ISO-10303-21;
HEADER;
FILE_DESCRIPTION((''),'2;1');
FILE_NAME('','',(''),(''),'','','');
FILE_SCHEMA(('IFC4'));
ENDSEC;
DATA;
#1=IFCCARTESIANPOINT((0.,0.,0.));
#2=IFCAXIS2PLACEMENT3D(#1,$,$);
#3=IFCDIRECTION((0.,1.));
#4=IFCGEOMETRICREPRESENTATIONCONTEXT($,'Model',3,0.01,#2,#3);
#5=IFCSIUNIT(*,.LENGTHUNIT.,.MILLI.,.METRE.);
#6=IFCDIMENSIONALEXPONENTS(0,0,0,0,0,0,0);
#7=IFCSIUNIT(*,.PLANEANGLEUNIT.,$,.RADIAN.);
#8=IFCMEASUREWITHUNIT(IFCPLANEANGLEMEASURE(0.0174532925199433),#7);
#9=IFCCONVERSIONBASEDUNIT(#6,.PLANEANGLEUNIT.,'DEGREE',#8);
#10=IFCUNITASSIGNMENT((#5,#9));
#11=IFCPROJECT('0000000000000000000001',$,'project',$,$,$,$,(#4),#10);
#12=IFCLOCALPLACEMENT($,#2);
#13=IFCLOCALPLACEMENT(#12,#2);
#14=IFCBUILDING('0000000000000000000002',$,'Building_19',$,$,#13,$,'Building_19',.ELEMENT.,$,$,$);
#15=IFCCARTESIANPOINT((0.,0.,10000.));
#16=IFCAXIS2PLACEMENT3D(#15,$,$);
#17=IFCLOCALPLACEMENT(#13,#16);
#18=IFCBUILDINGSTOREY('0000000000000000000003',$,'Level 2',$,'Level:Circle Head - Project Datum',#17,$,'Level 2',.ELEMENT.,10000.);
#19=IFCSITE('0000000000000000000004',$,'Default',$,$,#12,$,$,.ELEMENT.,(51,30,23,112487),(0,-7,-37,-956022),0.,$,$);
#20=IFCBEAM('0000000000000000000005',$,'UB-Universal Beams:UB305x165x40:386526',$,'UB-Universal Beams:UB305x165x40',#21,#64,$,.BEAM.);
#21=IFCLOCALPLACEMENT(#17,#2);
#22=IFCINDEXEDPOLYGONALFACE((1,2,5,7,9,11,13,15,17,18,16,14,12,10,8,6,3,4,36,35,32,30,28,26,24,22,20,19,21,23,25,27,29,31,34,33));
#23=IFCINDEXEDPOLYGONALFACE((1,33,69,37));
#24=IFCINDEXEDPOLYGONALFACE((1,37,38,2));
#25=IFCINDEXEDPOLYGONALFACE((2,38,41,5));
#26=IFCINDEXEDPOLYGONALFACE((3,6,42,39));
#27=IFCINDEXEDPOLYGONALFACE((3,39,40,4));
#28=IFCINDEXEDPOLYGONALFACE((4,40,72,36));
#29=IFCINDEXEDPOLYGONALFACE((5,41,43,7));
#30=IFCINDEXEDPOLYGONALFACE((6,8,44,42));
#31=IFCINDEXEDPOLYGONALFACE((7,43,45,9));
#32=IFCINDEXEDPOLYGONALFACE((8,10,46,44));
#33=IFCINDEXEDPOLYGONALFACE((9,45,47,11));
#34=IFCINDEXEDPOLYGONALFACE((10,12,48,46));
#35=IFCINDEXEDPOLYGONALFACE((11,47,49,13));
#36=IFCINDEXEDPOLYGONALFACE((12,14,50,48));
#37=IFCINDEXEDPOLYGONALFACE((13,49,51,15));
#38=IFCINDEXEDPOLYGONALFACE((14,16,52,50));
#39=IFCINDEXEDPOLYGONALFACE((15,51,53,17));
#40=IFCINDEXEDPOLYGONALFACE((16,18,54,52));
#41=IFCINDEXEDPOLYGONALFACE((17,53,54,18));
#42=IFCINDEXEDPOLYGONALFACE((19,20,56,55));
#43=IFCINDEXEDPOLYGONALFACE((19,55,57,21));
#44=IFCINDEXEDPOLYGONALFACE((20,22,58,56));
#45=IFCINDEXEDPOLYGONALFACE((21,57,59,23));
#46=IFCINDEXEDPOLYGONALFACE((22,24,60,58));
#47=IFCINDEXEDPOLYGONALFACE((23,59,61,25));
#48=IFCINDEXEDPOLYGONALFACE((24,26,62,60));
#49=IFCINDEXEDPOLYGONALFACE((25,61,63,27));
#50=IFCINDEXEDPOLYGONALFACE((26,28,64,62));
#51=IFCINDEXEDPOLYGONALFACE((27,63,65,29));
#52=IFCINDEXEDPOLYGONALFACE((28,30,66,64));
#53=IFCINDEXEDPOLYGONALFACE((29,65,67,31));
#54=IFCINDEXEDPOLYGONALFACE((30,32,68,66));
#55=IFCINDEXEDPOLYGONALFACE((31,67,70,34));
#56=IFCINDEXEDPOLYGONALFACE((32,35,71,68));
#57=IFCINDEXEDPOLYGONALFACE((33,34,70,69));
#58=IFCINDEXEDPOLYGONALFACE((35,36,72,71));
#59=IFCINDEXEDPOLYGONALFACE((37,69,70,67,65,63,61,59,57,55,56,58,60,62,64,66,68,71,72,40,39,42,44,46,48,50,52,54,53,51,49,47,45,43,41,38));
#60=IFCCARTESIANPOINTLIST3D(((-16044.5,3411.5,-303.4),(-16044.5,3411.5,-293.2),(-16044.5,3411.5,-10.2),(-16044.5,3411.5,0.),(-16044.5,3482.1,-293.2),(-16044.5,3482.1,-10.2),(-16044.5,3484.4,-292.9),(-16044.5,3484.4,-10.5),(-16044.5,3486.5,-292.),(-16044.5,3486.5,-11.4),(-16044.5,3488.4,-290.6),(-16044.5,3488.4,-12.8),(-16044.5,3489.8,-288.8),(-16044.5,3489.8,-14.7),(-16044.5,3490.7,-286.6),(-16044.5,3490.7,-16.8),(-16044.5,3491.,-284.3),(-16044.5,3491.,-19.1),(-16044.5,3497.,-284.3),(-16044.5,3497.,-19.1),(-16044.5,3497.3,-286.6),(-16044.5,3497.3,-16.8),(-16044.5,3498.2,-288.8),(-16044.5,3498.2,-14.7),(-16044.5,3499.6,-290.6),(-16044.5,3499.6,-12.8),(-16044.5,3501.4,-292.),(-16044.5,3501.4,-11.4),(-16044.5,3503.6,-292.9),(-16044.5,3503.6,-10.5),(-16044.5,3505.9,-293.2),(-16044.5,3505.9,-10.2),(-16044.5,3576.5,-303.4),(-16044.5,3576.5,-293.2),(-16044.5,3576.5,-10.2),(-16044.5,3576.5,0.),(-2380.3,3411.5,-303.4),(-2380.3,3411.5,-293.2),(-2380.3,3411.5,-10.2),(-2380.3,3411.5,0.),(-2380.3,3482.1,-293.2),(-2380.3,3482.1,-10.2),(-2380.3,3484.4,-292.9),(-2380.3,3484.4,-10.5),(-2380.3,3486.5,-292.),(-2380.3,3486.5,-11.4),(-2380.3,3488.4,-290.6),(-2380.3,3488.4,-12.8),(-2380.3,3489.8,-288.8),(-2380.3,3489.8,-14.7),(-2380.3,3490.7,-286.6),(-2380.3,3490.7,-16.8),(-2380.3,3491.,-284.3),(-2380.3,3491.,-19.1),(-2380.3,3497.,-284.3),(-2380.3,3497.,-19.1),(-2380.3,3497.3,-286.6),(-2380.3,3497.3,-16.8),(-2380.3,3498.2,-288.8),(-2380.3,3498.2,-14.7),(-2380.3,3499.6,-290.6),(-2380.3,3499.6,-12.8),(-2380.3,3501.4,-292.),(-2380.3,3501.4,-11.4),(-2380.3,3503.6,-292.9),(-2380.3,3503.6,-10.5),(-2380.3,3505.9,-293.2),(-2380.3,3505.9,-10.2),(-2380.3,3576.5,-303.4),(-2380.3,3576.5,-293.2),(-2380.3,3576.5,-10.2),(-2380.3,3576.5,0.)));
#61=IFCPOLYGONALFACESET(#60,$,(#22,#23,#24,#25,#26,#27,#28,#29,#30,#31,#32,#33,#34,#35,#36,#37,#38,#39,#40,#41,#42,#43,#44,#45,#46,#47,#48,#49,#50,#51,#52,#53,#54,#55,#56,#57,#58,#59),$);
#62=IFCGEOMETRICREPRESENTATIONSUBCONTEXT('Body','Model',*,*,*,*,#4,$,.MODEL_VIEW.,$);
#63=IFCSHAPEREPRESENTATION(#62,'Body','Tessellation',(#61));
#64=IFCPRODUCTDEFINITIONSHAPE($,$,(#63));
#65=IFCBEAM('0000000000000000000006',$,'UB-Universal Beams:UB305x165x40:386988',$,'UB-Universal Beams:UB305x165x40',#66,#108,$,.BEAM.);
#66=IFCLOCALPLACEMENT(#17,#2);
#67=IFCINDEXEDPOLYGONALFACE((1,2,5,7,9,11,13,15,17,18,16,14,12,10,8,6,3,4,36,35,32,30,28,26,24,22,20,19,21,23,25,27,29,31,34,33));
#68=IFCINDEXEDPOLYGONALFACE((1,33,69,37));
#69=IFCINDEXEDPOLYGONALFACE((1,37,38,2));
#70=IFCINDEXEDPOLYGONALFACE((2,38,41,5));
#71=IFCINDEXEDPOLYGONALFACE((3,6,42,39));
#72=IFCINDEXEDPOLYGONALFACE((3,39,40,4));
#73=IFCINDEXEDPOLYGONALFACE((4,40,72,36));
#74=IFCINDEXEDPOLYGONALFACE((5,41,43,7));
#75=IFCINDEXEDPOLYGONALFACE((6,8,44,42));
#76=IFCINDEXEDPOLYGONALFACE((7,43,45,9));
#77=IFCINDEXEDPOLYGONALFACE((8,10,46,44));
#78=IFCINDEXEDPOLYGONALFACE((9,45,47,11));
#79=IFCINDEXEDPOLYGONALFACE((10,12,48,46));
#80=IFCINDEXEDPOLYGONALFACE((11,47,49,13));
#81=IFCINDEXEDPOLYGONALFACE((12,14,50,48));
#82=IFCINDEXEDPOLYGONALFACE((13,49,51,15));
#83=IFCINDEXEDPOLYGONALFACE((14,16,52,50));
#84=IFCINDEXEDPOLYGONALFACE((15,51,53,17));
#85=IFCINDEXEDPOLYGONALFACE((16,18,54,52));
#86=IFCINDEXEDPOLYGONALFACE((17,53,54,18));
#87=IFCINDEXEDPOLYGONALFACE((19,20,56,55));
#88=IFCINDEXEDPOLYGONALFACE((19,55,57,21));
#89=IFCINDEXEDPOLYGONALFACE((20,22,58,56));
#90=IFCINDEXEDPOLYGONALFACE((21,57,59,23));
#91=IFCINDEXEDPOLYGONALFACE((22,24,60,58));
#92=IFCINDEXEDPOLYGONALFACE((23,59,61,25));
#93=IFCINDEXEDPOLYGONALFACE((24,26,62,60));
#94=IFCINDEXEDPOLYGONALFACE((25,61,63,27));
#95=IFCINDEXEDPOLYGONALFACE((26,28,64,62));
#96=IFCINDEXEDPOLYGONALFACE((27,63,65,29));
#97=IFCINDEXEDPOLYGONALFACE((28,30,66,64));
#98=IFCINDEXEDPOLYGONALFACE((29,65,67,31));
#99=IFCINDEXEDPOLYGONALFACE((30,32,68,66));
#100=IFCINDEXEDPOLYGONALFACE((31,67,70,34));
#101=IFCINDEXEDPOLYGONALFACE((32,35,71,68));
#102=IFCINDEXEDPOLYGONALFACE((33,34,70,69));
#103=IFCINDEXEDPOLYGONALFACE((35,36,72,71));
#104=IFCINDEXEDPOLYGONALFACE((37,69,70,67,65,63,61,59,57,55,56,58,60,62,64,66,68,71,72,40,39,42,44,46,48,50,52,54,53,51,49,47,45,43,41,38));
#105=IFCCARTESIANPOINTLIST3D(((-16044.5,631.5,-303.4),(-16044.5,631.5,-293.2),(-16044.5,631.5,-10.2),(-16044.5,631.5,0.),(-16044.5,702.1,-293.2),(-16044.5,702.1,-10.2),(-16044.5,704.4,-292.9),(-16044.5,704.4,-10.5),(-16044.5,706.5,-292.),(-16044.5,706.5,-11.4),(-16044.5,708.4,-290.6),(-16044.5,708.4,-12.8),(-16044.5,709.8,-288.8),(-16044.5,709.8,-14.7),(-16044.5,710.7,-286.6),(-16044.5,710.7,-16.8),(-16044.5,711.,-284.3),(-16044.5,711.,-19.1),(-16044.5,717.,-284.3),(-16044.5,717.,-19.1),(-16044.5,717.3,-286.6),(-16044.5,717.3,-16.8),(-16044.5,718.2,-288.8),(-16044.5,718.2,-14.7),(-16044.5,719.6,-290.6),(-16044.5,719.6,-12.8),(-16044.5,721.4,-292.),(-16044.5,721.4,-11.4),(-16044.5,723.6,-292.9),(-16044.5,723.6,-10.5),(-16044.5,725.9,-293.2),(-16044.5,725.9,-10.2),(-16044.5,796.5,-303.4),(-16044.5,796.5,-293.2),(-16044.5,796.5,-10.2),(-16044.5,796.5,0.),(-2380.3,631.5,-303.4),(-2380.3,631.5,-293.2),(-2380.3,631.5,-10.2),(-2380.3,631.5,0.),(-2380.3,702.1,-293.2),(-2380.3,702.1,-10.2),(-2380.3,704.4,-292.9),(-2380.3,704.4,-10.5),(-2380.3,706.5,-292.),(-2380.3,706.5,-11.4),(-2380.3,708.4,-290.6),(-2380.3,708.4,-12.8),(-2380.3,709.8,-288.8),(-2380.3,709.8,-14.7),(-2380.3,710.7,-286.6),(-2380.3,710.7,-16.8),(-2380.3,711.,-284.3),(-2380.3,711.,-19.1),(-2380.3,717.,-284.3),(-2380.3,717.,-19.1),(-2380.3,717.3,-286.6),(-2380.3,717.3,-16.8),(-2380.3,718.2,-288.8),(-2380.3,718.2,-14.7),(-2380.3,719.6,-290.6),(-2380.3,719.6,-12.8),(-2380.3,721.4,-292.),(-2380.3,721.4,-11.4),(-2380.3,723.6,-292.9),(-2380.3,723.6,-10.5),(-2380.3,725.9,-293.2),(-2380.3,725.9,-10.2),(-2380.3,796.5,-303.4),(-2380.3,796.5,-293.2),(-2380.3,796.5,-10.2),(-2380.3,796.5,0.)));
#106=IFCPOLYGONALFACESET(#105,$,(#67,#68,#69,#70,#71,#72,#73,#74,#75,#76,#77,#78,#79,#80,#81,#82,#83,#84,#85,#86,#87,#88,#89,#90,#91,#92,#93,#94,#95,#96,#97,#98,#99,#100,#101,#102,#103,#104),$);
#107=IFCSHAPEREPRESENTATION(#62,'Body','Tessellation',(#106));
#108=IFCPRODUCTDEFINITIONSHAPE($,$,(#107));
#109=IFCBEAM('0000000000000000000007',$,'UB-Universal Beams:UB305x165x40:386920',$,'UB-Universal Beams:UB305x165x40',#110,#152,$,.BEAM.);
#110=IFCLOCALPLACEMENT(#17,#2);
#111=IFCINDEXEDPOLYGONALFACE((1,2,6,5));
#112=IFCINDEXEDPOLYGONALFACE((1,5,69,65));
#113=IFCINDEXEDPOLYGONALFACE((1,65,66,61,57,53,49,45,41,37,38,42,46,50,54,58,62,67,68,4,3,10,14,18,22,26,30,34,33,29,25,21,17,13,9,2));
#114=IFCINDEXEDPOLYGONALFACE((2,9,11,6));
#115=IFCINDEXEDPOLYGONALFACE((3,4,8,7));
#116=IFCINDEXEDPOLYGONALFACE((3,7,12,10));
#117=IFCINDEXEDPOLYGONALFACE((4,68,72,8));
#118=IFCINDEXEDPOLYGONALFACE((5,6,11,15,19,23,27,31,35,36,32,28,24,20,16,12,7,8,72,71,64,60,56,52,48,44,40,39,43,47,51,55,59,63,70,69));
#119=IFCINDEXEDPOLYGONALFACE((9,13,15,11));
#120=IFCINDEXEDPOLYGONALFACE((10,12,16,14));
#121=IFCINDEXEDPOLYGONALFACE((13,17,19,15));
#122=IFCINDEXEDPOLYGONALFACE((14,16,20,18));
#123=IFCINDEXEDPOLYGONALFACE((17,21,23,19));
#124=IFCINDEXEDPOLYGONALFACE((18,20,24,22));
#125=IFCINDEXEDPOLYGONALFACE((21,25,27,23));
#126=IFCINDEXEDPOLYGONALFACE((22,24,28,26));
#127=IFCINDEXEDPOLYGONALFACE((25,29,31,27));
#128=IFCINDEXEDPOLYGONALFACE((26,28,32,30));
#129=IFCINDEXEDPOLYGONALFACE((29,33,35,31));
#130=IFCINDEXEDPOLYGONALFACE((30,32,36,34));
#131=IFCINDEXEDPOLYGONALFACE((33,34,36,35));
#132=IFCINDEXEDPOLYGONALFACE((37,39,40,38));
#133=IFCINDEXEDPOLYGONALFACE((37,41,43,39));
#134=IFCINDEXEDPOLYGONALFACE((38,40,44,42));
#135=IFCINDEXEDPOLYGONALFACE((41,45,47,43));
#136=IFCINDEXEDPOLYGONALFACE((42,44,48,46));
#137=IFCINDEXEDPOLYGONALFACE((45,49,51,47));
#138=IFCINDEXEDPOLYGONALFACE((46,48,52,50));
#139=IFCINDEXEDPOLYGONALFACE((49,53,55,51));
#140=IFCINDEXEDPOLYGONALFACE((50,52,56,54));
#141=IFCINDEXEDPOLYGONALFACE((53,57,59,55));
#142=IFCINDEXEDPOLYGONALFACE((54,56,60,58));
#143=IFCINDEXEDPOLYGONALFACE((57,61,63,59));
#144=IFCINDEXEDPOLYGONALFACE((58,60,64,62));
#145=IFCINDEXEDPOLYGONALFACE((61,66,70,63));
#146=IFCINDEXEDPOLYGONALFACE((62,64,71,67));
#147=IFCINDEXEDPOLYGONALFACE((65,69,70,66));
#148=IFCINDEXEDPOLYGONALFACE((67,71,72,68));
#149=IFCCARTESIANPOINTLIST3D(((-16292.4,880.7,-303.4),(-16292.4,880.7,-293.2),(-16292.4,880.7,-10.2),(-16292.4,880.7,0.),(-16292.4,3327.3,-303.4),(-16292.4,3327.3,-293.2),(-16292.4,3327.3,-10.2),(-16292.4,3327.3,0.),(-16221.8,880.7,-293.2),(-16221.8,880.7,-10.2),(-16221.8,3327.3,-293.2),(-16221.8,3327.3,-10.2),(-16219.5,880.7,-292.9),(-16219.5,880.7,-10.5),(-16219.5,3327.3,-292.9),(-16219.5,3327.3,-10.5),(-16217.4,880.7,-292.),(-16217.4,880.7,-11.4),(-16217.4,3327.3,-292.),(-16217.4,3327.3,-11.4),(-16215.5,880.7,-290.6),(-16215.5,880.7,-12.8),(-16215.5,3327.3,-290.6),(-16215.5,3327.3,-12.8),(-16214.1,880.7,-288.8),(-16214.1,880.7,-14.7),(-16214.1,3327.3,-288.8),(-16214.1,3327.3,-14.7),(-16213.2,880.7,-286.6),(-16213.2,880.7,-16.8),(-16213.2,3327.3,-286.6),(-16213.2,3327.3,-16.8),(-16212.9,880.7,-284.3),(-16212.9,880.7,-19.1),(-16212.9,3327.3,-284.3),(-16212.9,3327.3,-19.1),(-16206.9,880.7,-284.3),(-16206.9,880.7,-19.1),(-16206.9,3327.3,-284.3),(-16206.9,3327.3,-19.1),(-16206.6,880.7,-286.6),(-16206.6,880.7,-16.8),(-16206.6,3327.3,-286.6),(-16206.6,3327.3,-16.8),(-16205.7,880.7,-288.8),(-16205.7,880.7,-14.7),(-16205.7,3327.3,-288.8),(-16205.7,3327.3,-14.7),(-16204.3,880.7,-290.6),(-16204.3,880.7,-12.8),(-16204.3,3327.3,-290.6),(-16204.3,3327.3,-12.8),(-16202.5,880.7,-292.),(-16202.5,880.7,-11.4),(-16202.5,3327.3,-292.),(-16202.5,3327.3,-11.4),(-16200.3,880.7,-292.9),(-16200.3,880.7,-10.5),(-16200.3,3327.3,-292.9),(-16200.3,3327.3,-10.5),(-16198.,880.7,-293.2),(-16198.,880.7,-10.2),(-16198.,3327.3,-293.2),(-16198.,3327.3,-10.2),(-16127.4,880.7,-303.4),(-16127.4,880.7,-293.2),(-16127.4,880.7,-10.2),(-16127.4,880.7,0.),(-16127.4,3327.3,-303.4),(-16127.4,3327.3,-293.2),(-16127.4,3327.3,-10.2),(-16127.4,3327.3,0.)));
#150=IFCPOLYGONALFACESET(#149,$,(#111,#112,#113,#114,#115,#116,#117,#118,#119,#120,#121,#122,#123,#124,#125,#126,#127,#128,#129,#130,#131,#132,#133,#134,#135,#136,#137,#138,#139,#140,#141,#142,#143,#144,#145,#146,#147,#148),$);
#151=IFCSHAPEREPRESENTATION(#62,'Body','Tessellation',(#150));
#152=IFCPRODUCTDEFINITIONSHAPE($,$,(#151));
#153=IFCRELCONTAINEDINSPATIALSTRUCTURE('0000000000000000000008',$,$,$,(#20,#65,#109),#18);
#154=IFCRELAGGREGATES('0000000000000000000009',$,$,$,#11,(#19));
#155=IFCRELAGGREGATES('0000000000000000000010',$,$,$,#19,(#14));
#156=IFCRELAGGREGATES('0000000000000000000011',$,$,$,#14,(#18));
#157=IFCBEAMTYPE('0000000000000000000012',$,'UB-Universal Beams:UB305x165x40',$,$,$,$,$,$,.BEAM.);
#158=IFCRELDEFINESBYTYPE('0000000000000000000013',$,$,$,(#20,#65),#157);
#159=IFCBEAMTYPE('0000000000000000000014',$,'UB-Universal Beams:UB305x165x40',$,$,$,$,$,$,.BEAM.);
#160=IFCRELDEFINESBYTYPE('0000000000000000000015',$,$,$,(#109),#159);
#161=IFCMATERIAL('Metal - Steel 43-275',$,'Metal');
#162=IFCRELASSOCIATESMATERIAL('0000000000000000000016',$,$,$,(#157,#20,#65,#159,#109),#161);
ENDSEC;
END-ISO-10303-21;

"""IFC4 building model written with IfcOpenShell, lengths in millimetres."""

from ifc_helpers import new_model, entity, si_unit, converted_unit, direction, frame, origin, place, context, subcontext, project, spatial, line, arc, indexed_curve, outline, extrude, source, transform, mapped, material, type_object, type_shapes, element, save


model = new_model("IFC4")

# Units and contexts
model_context = context("Model", 3, precision=0.01, world=origin(), true_north=direction((0.0, 1.0)))
body_context = subcontext(model_context, "Body", "Model", "MODEL_VIEW")
ifc_project = project(units=[si_unit("LENGTHUNIT", "METRE", prefix="MILLI"), converted_unit("PLANEANGLEUNIT", "DEGREE", entity("IfcPlaneAngleMeasure", 0.0174532925199433), si_unit("PLANEANGLEUNIT", "RADIAN"), dimensions=[0, 0, 0, 0, 0, 0, 0])], contexts=[model_context])

# Site, building, storey
site_placement = place(None, origin())
site = spatial("IfcSite", under=ifc_project, at=site_placement, Name="Default", CompositionType="ELEMENT", RefLatitude=(51, 30, 23, 112487), RefLongitude=(0, -7, -37, -956022), RefElevation=0.0)
building_placement = place(site_placement, origin())
building = spatial("IfcBuilding", under=site, at=building_placement, Name="Building_19", LongName="Building_19", CompositionType="ELEMENT")
storey_placement = place(building_placement, frame((0.0, 0.0, 10000.0)))
storey = spatial("IfcBuildingStorey", under=building, at=storey_placement, Name="Level 2", ObjectType="Level:Circle Head - Project Datum", LongName="Level 2", CompositionType="ELEMENT", Elevation=10000.0)

# Beams
ifc_material_1 = material(Name="Metal - Steel 43-275", Category="Metal")
beam_type_1 = type_object("IfcBeamType", Name="UB-Universal Beams:UB305x165x40", PredefinedType="BEAM", material=ifc_material_1)
shared_shape_1 = source(origin(), body_context, "Body", "SweptSolid", [
    extrude(outline(indexed_curve([(-82.5, -141.5), (-82.5, -151.7), (82.5, -151.7), (82.5, -141.5), (11.9, -141.5), (5.6, -138.9), (3.0, -132.6), (3.0, 132.6), (5.6, 138.9), (11.9, 141.5), (82.5, 141.5), (82.5, 151.7), (-82.5, 151.7), (-82.5, 141.5), (-11.9, 141.5), (-5.6, 138.9), (-3.0, 132.6), (-3.0, -132.6), (-5.6, -138.9), (-11.9, -141.5)], segments=[line(1, 2, 3, 4, 5), arc(5, 6, 7), line(7, 8), arc(8, 9, 10), line(10, 11, 12, 13, 14, 15), arc(15, 16, 17), line(17, 18), arc(18, 19, 20), line(20, 1)], self_intersect=False)), frame((-6832.1, 0.0, 0.0), z_axis=(-1.0, 0.0, 0.0), x_axis=(0.0, -1.0, 0.0)), (0.0, 0.0, -1.0), 13664.2),
])
type_shapes(beam_type_1, [shared_shape_1])
for number, where, name in (
    (1, (-9212.4, 3494.0, -151.7), "UB-Universal Beams:UB305x165x40:386526"),
    (2, (-9212.4, 714.0, -151.7), "UB-Universal Beams:UB305x165x40:386988"),
):
    element("IfcBeam", number, at=place(storey_placement, frame(where)), inside=storey, type_object=beam_type_1, material=ifc_material_1, Name=name, ObjectType="UB-Universal Beams:UB305x165x40", PredefinedType="BEAM", context=body_context, shape_type="MappedRepresentation", body=[
        mapped(shared_shape_1, transform((0.0, 0.0, 0.0), scale=1.0)),
    ])
beam_type_2 = type_object("IfcBeamType", Name="UB-Universal Beams:UB305x165x40", PredefinedType="BEAM", material=ifc_material_1)
shared_shape_2 = source(origin(), body_context, "Body", "SweptSolid", [
    extrude(outline(indexed_curve([(-82.5, -141.5), (-82.5, -151.7), (82.5, -151.7), (82.5, -141.5), (11.9, -141.5), (5.6, -138.9), (3.0, -132.6), (3.0, 132.6), (5.6, 138.9), (11.9, 141.5), (82.5, 141.5), (82.5, 151.7), (-82.5, 151.7), (-82.5, 141.5), (-11.9, 141.5), (-5.6, 138.9), (-3.0, 132.6), (-3.0, -132.6), (-5.6, -138.9), (-11.9, -141.5)], segments=[line(1, 2, 3, 4, 5), arc(5, 6, 7), line(7, 8), arc(8, 9, 10), line(10, 11, 12, 13, 14, 15), arc(15, 16, 17), line(17, 18), arc(18, 19, 20), line(20, 1)], self_intersect=False)), frame((-1223.3, 0.0, 0.0), z_axis=(-1.0, 0.0, 0.0), x_axis=(0.0, -1.0, 0.0)), (0.0, 0.0, -1.0), 2446.6),
])
type_shapes(beam_type_2, [shared_shape_2])
beam_1_placement = place(storey_placement, frame((-16209.9, 2104.0, -151.7), z_axis=(0.0, 0.0, 1.0), x_axis=(0.0, -1.0, 0.0)))
element("IfcBeam", 3, at=beam_1_placement, inside=storey, type_object=beam_type_2, material=ifc_material_1, Name="UB-Universal Beams:UB305x165x40:386920", ObjectType="UB-Universal Beams:UB305x165x40", PredefinedType="BEAM", context=body_context, shape_type="MappedRepresentation", body=[
    mapped(shared_shape_2, transform((0.0, 0.0, 0.0), scale=1.0)),
])

save(model, "model.ifc")
